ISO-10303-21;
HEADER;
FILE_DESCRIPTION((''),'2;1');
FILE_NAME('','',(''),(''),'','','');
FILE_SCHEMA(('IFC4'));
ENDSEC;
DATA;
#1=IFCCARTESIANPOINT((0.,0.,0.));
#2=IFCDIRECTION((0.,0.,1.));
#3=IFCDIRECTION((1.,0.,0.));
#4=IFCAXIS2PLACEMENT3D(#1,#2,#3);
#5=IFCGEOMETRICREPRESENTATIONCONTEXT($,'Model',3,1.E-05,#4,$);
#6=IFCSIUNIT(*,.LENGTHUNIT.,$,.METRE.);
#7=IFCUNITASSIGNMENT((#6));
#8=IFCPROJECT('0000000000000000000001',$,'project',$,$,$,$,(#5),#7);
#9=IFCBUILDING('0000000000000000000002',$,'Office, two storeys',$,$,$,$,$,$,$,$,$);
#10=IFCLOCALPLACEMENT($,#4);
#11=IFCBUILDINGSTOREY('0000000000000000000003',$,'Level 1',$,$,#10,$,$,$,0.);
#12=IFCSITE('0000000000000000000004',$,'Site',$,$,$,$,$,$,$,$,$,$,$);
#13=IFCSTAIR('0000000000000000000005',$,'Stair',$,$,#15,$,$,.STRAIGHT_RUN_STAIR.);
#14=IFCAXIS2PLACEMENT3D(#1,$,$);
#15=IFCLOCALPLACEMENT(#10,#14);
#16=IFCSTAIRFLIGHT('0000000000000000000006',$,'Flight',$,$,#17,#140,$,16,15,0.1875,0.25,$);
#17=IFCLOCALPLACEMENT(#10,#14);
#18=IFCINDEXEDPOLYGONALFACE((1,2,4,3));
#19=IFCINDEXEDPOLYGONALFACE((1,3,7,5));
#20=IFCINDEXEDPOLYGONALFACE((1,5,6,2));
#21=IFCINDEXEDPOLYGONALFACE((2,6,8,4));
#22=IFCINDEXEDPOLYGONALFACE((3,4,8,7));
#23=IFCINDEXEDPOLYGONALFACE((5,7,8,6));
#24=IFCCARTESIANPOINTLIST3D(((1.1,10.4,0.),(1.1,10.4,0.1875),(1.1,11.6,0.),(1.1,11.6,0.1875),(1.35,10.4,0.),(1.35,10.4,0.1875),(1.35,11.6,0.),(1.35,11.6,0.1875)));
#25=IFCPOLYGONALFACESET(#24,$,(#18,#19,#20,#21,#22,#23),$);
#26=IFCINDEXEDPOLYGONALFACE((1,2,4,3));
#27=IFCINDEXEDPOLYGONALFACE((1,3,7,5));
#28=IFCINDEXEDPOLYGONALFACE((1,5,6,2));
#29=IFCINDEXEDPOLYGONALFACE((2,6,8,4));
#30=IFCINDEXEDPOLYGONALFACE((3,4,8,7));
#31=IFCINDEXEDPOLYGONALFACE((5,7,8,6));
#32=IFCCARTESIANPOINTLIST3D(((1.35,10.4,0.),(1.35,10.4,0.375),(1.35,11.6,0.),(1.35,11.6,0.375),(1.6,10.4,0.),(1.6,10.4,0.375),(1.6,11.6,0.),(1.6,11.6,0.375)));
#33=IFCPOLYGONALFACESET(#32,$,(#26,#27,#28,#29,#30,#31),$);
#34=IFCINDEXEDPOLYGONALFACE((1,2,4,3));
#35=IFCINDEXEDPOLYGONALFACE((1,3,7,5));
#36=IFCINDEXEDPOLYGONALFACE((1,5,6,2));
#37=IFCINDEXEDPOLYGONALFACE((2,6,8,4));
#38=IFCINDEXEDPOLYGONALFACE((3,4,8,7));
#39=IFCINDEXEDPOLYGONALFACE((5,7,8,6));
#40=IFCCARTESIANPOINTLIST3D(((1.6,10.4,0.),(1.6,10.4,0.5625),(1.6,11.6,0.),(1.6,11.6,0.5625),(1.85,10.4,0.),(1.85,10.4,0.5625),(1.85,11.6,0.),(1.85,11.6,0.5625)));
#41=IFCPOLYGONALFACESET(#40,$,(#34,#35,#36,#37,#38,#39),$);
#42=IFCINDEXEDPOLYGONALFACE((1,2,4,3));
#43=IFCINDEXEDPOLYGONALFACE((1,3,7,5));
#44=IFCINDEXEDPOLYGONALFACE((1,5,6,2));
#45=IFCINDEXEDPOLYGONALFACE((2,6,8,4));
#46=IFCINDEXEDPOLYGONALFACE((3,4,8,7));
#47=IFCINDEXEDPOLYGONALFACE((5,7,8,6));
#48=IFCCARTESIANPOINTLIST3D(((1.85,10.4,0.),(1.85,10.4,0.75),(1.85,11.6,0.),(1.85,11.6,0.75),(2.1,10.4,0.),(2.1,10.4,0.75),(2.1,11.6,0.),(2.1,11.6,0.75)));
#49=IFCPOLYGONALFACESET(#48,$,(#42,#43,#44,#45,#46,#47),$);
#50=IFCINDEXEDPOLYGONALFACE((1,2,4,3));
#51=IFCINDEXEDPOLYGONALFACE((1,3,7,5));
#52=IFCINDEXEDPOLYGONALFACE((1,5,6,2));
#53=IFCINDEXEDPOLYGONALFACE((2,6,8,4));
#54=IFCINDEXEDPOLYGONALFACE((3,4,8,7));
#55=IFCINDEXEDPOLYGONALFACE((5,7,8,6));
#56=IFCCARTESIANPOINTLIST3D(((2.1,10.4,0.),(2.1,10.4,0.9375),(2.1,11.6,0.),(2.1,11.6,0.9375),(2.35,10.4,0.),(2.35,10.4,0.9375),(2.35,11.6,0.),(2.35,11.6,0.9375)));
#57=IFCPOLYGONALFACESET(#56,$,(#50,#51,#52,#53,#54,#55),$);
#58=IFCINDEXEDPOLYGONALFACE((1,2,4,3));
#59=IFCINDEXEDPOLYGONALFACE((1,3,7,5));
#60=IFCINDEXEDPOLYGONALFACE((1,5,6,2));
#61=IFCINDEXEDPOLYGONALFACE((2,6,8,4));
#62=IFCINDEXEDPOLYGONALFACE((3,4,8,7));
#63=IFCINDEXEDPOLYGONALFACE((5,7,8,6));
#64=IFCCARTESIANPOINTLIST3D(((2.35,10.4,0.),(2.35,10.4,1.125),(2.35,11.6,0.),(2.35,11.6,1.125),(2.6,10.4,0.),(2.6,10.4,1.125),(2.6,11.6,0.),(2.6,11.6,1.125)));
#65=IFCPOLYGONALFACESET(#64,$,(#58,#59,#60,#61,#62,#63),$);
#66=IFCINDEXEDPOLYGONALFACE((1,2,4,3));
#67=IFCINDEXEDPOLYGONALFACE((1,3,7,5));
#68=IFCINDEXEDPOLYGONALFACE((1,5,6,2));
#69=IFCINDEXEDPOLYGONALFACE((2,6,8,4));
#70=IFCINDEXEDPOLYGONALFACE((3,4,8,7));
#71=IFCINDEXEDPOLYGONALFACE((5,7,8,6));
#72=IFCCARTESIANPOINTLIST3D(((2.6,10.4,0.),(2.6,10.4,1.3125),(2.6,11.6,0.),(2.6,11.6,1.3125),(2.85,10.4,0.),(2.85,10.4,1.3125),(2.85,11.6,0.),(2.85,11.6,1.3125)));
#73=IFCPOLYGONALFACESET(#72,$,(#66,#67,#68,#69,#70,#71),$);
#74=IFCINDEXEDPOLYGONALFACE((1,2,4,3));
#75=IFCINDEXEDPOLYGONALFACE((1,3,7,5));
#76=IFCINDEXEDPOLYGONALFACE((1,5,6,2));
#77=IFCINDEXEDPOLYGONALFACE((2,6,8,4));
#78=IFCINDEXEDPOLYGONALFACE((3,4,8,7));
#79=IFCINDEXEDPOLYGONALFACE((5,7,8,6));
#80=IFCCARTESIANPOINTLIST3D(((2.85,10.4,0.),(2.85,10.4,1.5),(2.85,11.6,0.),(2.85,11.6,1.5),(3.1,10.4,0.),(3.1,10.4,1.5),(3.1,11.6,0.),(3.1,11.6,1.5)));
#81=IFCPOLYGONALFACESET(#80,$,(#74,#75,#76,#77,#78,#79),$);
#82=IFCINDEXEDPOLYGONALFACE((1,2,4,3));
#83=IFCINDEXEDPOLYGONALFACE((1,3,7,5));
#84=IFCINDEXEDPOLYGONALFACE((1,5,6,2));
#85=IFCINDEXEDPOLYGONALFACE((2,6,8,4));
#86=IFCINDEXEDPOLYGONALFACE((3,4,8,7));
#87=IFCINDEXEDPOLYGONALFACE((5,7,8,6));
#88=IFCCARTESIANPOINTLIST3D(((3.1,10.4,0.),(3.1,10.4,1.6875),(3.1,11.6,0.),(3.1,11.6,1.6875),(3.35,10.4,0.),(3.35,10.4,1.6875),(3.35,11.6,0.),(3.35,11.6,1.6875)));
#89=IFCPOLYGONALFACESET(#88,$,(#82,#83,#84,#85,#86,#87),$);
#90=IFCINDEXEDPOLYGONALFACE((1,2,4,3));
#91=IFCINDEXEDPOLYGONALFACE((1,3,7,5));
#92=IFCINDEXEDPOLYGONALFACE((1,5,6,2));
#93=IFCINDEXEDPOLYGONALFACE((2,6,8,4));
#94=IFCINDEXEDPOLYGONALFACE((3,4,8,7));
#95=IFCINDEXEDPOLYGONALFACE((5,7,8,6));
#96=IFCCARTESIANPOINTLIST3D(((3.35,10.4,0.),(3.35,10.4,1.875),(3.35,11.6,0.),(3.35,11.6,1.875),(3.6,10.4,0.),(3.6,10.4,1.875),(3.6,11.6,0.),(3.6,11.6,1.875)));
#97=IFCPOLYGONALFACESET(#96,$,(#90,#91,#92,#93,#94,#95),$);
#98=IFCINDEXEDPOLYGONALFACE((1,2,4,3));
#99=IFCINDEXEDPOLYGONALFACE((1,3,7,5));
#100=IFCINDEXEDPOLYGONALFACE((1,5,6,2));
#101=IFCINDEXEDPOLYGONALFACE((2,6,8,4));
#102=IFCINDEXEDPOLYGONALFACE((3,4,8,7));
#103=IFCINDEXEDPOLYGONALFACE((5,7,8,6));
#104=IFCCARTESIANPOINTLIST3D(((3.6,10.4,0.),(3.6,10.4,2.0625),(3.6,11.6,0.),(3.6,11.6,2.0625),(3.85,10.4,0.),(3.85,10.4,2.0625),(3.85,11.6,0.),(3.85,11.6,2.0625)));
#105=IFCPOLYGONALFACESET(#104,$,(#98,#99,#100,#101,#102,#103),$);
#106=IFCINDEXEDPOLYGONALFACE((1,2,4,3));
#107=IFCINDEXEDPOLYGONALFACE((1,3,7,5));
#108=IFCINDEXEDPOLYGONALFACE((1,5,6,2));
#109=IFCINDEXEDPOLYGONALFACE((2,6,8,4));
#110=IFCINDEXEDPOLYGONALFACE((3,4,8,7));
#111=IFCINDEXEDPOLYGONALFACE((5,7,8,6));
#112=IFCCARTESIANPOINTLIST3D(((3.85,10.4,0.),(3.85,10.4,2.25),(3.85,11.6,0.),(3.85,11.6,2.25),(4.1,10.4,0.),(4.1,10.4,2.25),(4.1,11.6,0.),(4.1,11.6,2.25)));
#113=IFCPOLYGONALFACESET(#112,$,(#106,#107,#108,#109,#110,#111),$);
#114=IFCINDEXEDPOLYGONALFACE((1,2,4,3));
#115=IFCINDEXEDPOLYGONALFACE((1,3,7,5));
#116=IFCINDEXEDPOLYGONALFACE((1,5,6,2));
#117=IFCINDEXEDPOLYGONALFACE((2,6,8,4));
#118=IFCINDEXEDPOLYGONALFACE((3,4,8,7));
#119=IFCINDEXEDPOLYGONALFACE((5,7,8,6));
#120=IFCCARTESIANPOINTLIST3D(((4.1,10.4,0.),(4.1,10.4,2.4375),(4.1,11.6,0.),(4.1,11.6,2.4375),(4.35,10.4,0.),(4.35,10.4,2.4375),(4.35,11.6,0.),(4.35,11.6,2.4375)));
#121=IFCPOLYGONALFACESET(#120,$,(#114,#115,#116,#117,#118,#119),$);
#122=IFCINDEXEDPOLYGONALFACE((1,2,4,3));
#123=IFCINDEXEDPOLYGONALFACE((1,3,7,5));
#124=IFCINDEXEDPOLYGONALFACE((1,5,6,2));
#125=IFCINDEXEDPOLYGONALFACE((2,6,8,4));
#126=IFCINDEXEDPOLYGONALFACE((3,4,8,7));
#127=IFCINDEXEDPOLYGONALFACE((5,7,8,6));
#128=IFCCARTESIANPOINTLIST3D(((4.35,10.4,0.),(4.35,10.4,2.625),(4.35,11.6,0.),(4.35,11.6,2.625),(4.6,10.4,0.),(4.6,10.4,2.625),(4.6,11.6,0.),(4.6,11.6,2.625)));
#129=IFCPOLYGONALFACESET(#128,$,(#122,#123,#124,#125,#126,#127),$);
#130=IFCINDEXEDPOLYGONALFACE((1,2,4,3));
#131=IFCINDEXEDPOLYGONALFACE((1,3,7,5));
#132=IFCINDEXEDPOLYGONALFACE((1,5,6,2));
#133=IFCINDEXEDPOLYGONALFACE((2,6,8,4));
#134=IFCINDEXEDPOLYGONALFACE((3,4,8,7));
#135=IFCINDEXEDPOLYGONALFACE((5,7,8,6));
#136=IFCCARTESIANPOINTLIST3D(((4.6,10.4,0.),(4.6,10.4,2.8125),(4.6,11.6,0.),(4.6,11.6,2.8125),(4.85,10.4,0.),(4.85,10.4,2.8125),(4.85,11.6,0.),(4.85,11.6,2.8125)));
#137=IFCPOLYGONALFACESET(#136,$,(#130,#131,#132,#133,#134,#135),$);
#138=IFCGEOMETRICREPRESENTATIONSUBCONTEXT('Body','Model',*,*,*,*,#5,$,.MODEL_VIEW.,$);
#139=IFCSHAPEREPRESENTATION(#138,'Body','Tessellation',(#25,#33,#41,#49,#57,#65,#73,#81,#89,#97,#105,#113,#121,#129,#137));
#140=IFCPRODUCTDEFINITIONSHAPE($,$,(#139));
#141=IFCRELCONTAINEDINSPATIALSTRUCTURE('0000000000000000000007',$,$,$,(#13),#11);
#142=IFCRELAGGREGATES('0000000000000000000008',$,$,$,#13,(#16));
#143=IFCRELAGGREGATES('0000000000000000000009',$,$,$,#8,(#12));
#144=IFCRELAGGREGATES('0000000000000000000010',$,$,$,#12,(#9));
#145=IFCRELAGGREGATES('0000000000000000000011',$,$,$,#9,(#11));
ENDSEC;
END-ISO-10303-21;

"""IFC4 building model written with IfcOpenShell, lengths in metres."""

from ifc_helpers import new_model, si_unit, frame, origin_with_axes, place, context, subcontext, project, spatial, line, indexed_curve, outline, extrude, element, aggregate, save


model = new_model("IFC4")

# Units and contexts
model_context = context("Model", 3, precision=1e-05, world=origin_with_axes())
body_context = subcontext(model_context, "Body", "Model", "MODEL_VIEW")
ifc_project = project(units=[si_unit("LENGTHUNIT", "METRE")], contexts=[model_context])

# Site, building, storey
site = spatial("IfcSite", under=ifc_project, Name="Site")
building = spatial("IfcBuilding", under=site, Name="Office, two storeys")
storey_placement = place(None, origin_with_axes())
storey = spatial("IfcBuildingStorey", under=building, at=storey_placement, Name="Level 1", Elevation=0.0)

# Stair, stair flight
stair_placement = place(storey_placement, frame((1.1, 11.0, 0.0), z_axis=(0.0, 0.0, 1.0), x_axis=(1.0, 0.0, 0.0)))
stair = element("IfcStair", 1, at=stair_placement, inside=storey, Name="Stair", PredefinedType="STRAIGHT_RUN_STAIR")
stair_flight_placement = place(stair_placement, origin_with_axes())
stair_flight = element("IfcStairFlight", 2, at=stair_flight_placement, Name="Flight", NumberOfRisers=16, NumberOfTreads=15, RiserHeight=0.1875, TreadLength=0.25, context=body_context, shape_type="SweptSolid", body=[
    extrude(outline(indexed_curve([(0.0, 0.0), (0.25, 0.0), (0.25, 1.2), (0.0, 1.2)], segments=[line(1, 2, 3, 4, 1)])), frame((0.0, -0.6, 0.0), z_axis=(0.0, 0.0, 1.0), x_axis=(1.0, 0.0, 0.0)), (0.0, 0.0, 1.0), 0.1875),
    extrude(outline(indexed_curve([(0.0, 0.0), (0.25, 0.0), (0.25, 1.2), (0.0, 1.2)], segments=[line(1, 2, 3, 4, 1)])), frame((0.25, -0.6, 0.0), z_axis=(0.0, 0.0, 1.0), x_axis=(1.0, 0.0, 0.0)), (0.0, 0.0, 1.0), 0.375),
    extrude(outline(indexed_curve([(0.0, 0.0), (0.25, 0.0), (0.25, 1.2), (0.0, 1.2)], segments=[line(1, 2, 3, 4, 1)])), frame((0.5, -0.6, 0.0), z_axis=(0.0, 0.0, 1.0), x_axis=(1.0, 0.0, 0.0)), (0.0, 0.0, 1.0), 0.5625),
    extrude(outline(indexed_curve([(0.0, 0.0), (0.25, 0.0), (0.25, 1.2), (0.0, 1.2)], segments=[line(1, 2, 3, 4, 1)])), frame((0.75, -0.6, 0.0), z_axis=(0.0, 0.0, 1.0), x_axis=(1.0, 0.0, 0.0)), (0.0, 0.0, 1.0), 0.75),
    extrude(outline(indexed_curve([(0.0, 0.0), (0.25, 0.0), (0.25, 1.2), (0.0, 1.2)], segments=[line(1, 2, 3, 4, 1)])), frame((1.0, -0.6, 0.0), z_axis=(0.0, 0.0, 1.0), x_axis=(1.0, 0.0, 0.0)), (0.0, 0.0, 1.0), 0.9375),
    extrude(outline(indexed_curve([(0.0, 0.0), (0.25, 0.0), (0.25, 1.2), (0.0, 1.2)], segments=[line(1, 2, 3, 4, 1)])), frame((1.25, -0.6, 0.0), z_axis=(0.0, 0.0, 1.0), x_axis=(1.0, 0.0, 0.0)), (0.0, 0.0, 1.0), 1.125),
    extrude(outline(indexed_curve([(0.0, 0.0), (0.25, 0.0), (0.25, 1.2), (0.0, 1.2)], segments=[line(1, 2, 3, 4, 1)])), frame((1.5, -0.6, 0.0), z_axis=(0.0, 0.0, 1.0), x_axis=(1.0, 0.0, 0.0)), (0.0, 0.0, 1.0), 1.3125),
    extrude(outline(indexed_curve([(0.0, 0.0), (0.25, 0.0), (0.25, 1.2), (0.0, 1.2)], segments=[line(1, 2, 3, 4, 1)])), frame((1.75, -0.6, 0.0), z_axis=(0.0, 0.0, 1.0), x_axis=(1.0, 0.0, 0.0)), (0.0, 0.0, 1.0), 1.5),
    extrude(outline(indexed_curve([(0.0, 0.0), (0.25, 0.0), (0.25, 1.2), (0.0, 1.2)], segments=[line(1, 2, 3, 4, 1)])), frame((2.0, -0.6, 0.0), z_axis=(0.0, 0.0, 1.0), x_axis=(1.0, 0.0, 0.0)), (0.0, 0.0, 1.0), 1.6875),
    extrude(outline(indexed_curve([(0.0, 0.0), (0.25, 0.0), (0.25, 1.2), (0.0, 1.2)], segments=[line(1, 2, 3, 4, 1)])), frame((2.25, -0.6, 0.0), z_axis=(0.0, 0.0, 1.0), x_axis=(1.0, 0.0, 0.0)), (0.0, 0.0, 1.0), 1.875),
    extrude(outline(indexed_curve([(0.0, 0.0), (0.25, 0.0), (0.25, 1.2), (0.0, 1.2)], segments=[line(1, 2, 3, 4, 1)])), frame((2.5, -0.6, 0.0), z_axis=(0.0, 0.0, 1.0), x_axis=(1.0, 0.0, 0.0)), (0.0, 0.0, 1.0), 2.0625),
    extrude(outline(indexed_curve([(0.0, 0.0), (0.25, 0.0), (0.25, 1.2), (0.0, 1.2)], segments=[line(1, 2, 3, 4, 1)])), frame((2.75, -0.6, 0.0), z_axis=(0.0, 0.0, 1.0), x_axis=(1.0, 0.0, 0.0)), (0.0, 0.0, 1.0), 2.25),
    extrude(outline(indexed_curve([(0.0, 0.0), (0.25, 0.0), (0.25, 1.2), (0.0, 1.2)], segments=[line(1, 2, 3, 4, 1)])), frame((3.0, -0.6, 0.0), z_axis=(0.0, 0.0, 1.0), x_axis=(1.0, 0.0, 0.0)), (0.0, 0.0, 1.0), 2.4375),
    extrude(outline(indexed_curve([(0.0, 0.0), (0.25, 0.0), (0.25, 1.2), (0.0, 1.2)], segments=[line(1, 2, 3, 4, 1)])), frame((3.25, -0.6, 0.0), z_axis=(0.0, 0.0, 1.0), x_axis=(1.0, 0.0, 0.0)), (0.0, 0.0, 1.0), 2.625),
    extrude(outline(indexed_curve([(0.0, 0.0), (0.25, 0.0), (0.25, 1.2), (0.0, 1.2)], segments=[line(1, 2, 3, 4, 1)])), frame((3.5, -0.6, 0.0), z_axis=(0.0, 0.0, 1.0), x_axis=(1.0, 0.0, 0.0)), (0.0, 0.0, 1.0), 2.8125),
])
aggregate(stair, [stair_flight])

save(model, "model.ifc")
